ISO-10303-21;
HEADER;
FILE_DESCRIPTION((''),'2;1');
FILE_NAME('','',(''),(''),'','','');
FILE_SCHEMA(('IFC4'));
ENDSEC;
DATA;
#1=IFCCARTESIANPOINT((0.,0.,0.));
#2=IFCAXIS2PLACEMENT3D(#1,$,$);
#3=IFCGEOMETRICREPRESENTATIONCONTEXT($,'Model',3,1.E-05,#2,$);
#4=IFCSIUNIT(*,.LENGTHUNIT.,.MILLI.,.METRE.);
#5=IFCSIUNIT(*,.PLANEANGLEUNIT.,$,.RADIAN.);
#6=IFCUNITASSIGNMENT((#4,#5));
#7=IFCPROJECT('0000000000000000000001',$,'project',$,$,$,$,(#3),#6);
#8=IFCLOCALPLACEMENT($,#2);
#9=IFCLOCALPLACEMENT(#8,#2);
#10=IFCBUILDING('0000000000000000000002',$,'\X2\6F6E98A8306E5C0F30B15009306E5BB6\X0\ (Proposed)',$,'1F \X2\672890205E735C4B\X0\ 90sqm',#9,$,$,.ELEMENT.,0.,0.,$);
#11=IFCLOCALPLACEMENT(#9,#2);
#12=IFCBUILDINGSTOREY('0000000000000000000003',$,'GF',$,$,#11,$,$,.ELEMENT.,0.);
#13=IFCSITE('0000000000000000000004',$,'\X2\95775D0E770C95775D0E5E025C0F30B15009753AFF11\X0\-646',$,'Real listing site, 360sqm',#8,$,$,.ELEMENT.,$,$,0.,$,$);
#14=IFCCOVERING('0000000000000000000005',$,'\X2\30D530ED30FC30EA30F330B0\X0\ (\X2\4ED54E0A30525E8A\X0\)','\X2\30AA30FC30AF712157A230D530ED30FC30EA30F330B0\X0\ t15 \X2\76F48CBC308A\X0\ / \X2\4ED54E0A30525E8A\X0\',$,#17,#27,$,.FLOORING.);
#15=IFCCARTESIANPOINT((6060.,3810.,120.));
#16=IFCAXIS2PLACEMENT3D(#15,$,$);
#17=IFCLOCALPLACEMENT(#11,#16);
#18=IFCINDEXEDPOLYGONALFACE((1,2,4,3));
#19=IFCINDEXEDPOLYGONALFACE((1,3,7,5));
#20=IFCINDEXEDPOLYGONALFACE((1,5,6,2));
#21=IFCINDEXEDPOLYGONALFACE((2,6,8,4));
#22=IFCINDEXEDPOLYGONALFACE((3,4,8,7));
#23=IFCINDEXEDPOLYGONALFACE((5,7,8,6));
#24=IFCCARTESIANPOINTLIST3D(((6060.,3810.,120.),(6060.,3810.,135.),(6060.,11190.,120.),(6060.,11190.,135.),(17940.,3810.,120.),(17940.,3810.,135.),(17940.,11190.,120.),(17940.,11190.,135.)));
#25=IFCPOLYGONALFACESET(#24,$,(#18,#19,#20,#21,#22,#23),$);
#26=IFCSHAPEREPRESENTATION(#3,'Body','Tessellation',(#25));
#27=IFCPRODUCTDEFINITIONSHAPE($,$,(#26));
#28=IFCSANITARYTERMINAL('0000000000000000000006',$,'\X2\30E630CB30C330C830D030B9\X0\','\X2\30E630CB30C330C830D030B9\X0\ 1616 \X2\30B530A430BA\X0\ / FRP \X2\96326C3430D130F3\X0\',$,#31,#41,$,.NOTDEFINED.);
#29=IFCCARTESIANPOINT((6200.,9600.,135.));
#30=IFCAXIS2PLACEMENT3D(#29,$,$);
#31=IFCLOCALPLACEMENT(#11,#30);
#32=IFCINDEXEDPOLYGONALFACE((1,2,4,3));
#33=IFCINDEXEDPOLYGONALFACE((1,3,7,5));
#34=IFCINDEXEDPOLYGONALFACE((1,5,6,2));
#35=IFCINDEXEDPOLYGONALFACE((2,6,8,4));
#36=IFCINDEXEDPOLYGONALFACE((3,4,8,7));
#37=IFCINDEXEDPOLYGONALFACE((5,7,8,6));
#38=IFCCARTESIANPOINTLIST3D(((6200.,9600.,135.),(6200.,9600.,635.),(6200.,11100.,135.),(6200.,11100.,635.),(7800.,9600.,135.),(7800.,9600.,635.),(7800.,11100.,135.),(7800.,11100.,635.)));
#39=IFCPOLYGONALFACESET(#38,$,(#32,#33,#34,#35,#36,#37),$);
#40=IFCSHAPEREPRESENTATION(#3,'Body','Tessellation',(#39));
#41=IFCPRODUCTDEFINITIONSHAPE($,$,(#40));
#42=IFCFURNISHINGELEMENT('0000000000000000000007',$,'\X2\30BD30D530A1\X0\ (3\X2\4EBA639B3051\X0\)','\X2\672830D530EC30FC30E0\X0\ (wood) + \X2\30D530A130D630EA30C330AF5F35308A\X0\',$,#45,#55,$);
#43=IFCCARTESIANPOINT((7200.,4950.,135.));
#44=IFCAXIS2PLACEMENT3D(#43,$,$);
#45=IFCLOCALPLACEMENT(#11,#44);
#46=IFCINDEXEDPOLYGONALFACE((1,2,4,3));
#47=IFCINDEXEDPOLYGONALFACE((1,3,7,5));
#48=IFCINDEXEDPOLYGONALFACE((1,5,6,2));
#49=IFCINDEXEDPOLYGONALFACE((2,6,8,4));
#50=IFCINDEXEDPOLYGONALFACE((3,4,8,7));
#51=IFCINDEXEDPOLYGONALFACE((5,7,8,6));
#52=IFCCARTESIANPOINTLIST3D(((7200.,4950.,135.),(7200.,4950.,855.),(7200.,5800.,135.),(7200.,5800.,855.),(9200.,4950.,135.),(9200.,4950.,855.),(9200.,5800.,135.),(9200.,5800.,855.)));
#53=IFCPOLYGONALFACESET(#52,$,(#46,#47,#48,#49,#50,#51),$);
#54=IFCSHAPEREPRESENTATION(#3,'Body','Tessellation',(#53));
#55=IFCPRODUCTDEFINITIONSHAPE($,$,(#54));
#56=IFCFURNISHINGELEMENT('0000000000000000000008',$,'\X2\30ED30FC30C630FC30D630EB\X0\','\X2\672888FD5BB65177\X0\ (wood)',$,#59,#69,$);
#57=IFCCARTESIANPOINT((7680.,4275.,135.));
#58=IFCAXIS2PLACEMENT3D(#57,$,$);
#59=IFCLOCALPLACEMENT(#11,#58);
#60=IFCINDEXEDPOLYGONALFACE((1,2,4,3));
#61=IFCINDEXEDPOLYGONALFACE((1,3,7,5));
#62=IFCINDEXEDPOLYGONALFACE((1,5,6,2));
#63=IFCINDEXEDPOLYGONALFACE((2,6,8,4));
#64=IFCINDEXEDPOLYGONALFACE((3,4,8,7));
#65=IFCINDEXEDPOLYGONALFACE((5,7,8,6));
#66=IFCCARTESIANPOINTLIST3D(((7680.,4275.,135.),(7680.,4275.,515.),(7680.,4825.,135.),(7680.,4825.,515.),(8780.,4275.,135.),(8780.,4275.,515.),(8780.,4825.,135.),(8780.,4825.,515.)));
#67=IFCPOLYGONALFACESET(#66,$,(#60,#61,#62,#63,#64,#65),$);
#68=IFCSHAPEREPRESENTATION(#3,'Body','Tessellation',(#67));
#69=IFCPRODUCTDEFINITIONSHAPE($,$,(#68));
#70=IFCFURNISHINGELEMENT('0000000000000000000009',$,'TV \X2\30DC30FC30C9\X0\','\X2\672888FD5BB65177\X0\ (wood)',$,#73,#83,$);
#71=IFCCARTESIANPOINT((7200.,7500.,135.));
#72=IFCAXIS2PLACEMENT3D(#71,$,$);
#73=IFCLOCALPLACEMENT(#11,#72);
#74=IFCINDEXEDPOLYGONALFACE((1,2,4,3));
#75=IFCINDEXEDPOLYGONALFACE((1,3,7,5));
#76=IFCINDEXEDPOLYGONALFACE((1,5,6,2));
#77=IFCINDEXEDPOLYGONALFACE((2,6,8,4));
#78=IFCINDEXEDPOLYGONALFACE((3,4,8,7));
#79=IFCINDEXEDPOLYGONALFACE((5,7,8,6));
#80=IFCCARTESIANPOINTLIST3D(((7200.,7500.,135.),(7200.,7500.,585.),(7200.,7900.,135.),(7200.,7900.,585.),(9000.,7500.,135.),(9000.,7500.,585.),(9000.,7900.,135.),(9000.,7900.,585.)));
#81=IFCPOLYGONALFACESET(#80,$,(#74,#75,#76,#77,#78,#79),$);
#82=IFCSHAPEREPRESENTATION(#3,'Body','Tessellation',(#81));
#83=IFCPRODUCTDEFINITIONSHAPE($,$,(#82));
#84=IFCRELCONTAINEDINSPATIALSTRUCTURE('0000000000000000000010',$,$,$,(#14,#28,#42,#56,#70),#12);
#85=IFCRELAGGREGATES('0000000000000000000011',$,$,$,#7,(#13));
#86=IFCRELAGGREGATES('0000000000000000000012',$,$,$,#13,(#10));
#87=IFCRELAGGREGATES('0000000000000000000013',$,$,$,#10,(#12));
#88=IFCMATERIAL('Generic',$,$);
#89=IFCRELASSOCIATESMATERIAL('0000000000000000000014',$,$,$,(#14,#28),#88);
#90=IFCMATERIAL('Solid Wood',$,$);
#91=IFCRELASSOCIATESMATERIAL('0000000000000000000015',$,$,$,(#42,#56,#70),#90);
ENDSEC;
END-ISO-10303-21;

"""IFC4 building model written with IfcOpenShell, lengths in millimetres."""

from ifc_helpers import new_model, si_unit, frame, frame_2d, origin, place, context, project, spatial, rectangle, extrude, material, element, save


model = new_model("IFC4")

# Units and contexts
model_context = context("Model", 3, precision=1e-05, world=origin())
ifc_project = project(units=[si_unit("LENGTHUNIT", "METRE", prefix="MILLI"), si_unit("PLANEANGLEUNIT", "RADIAN")], contexts=[model_context])

# Site, building, storey
site_placement = place(None, origin())
site = spatial("IfcSite", under=ifc_project, at=site_placement, Name="長崎県長崎市小ケ倉町１-646", ObjectType="Real listing site, 360sqm", CompositionType="ELEMENT", RefElevation=0.0)
building_placement = place(site_placement, origin())
building = spatial("IfcBuilding", under=site, at=building_placement, Name="潮風の小ケ倉の家 (Proposed)", ObjectType="1F 木造平屋 90sqm", CompositionType="ELEMENT", ElevationOfRefHeight=0.0, ElevationOfTerrain=0.0)
storey_placement = place(building_placement, origin())
storey = spatial("IfcBuildingStorey", under=building, at=storey_placement, Name="GF", CompositionType="ELEMENT", Elevation=0.0)

# Shared definitions
ifc_material_1 = material(Name="Solid Wood")

# Covering
ifc_material_2 = material(Name="Generic")
covering_placement = place(storey_placement, frame((6060.0, 3810.0, 120.0)))
element("IfcCovering", 1, at=covering_placement, inside=storey, material=ifc_material_2, Name="フローリング (仕上げ床)", Description="オーク無垢フローリング t15 直貼り / 仕上げ床", PredefinedType="FLOORING", context=model_context, shape_type="SweptSolid", body=[
    extrude(rectangle(XDim=11880.0, YDim=7380.0, at=frame_2d((5940.0, 3690.0))), frame((6060.0, 3810.0, 120.0)), (0.0, 0.0, 1.0), 15.0),
])

# Sanitary terminal
sanitary_terminal_placement = place(storey_placement, frame((6200.0, 9600.0, 135.0)))
element("IfcSanitaryTerminal", 2, at=sanitary_terminal_placement, inside=storey, material=ifc_material_2, Name="ユニットバス", Description="ユニットバス 1616 サイズ / FRP 防水パン", PredefinedType="NOTDEFINED", context=model_context, shape_type="SweptSolid", body=[
    extrude(rectangle(XDim=1600.0, YDim=1500.0, at=frame_2d((800.0, 750.0))), frame((6200.0, 9600.0, 135.0)), (0.0, 0.0, 1.0), 500.0),
])

# Furnishing elements
furnishing_1_placement = place(storey_placement, frame((7200.0, 4950.0, 135.0)))
element("IfcFurnishingElement", 3, at=furnishing_1_placement, inside=storey, material=ifc_material_1, Name="ソファ (3人掛け)", Description="木フレーム (wood) + ファブリック張り", context=model_context, shape_type="SweptSolid", body=[
    extrude(rectangle(XDim=2000.0, YDim=850.0, at=frame_2d((1000.0, 425.0))), frame((7200.0, 4950.0, 135.0)), (0.0, 0.0, 1.0), 720.0),
])
furnishing_2_placement = place(storey_placement, frame((7680.0, 4275.0, 135.0)))
element("IfcFurnishingElement", 4, at=furnishing_2_placement, inside=storey, material=ifc_material_1, Name="ローテーブル", Description="木製家具 (wood)", context=model_context, shape_type="SweptSolid", body=[
    extrude(rectangle(XDim=1100.0, YDim=550.0, at=frame_2d((550.0, 275.0))), frame((7680.0, 4275.0, 135.0)), (0.0, 0.0, 1.0), 380.0),
])
furnishing_3_placement = place(storey_placement, frame((7200.0, 7500.0, 135.0)))
element("IfcFurnishingElement", 5, at=furnishing_3_placement, inside=storey, material=ifc_material_1, Name="TV ボード", Description="木製家具 (wood)", context=model_context, shape_type="SweptSolid", body=[
    extrude(rectangle(XDim=1800.0, YDim=400.0, at=frame_2d((900.0, 200.0))), frame((7200.0, 7500.0, 135.0)), (0.0, 0.0, 1.0), 450.0),
])

save(model, "model.ifc")
